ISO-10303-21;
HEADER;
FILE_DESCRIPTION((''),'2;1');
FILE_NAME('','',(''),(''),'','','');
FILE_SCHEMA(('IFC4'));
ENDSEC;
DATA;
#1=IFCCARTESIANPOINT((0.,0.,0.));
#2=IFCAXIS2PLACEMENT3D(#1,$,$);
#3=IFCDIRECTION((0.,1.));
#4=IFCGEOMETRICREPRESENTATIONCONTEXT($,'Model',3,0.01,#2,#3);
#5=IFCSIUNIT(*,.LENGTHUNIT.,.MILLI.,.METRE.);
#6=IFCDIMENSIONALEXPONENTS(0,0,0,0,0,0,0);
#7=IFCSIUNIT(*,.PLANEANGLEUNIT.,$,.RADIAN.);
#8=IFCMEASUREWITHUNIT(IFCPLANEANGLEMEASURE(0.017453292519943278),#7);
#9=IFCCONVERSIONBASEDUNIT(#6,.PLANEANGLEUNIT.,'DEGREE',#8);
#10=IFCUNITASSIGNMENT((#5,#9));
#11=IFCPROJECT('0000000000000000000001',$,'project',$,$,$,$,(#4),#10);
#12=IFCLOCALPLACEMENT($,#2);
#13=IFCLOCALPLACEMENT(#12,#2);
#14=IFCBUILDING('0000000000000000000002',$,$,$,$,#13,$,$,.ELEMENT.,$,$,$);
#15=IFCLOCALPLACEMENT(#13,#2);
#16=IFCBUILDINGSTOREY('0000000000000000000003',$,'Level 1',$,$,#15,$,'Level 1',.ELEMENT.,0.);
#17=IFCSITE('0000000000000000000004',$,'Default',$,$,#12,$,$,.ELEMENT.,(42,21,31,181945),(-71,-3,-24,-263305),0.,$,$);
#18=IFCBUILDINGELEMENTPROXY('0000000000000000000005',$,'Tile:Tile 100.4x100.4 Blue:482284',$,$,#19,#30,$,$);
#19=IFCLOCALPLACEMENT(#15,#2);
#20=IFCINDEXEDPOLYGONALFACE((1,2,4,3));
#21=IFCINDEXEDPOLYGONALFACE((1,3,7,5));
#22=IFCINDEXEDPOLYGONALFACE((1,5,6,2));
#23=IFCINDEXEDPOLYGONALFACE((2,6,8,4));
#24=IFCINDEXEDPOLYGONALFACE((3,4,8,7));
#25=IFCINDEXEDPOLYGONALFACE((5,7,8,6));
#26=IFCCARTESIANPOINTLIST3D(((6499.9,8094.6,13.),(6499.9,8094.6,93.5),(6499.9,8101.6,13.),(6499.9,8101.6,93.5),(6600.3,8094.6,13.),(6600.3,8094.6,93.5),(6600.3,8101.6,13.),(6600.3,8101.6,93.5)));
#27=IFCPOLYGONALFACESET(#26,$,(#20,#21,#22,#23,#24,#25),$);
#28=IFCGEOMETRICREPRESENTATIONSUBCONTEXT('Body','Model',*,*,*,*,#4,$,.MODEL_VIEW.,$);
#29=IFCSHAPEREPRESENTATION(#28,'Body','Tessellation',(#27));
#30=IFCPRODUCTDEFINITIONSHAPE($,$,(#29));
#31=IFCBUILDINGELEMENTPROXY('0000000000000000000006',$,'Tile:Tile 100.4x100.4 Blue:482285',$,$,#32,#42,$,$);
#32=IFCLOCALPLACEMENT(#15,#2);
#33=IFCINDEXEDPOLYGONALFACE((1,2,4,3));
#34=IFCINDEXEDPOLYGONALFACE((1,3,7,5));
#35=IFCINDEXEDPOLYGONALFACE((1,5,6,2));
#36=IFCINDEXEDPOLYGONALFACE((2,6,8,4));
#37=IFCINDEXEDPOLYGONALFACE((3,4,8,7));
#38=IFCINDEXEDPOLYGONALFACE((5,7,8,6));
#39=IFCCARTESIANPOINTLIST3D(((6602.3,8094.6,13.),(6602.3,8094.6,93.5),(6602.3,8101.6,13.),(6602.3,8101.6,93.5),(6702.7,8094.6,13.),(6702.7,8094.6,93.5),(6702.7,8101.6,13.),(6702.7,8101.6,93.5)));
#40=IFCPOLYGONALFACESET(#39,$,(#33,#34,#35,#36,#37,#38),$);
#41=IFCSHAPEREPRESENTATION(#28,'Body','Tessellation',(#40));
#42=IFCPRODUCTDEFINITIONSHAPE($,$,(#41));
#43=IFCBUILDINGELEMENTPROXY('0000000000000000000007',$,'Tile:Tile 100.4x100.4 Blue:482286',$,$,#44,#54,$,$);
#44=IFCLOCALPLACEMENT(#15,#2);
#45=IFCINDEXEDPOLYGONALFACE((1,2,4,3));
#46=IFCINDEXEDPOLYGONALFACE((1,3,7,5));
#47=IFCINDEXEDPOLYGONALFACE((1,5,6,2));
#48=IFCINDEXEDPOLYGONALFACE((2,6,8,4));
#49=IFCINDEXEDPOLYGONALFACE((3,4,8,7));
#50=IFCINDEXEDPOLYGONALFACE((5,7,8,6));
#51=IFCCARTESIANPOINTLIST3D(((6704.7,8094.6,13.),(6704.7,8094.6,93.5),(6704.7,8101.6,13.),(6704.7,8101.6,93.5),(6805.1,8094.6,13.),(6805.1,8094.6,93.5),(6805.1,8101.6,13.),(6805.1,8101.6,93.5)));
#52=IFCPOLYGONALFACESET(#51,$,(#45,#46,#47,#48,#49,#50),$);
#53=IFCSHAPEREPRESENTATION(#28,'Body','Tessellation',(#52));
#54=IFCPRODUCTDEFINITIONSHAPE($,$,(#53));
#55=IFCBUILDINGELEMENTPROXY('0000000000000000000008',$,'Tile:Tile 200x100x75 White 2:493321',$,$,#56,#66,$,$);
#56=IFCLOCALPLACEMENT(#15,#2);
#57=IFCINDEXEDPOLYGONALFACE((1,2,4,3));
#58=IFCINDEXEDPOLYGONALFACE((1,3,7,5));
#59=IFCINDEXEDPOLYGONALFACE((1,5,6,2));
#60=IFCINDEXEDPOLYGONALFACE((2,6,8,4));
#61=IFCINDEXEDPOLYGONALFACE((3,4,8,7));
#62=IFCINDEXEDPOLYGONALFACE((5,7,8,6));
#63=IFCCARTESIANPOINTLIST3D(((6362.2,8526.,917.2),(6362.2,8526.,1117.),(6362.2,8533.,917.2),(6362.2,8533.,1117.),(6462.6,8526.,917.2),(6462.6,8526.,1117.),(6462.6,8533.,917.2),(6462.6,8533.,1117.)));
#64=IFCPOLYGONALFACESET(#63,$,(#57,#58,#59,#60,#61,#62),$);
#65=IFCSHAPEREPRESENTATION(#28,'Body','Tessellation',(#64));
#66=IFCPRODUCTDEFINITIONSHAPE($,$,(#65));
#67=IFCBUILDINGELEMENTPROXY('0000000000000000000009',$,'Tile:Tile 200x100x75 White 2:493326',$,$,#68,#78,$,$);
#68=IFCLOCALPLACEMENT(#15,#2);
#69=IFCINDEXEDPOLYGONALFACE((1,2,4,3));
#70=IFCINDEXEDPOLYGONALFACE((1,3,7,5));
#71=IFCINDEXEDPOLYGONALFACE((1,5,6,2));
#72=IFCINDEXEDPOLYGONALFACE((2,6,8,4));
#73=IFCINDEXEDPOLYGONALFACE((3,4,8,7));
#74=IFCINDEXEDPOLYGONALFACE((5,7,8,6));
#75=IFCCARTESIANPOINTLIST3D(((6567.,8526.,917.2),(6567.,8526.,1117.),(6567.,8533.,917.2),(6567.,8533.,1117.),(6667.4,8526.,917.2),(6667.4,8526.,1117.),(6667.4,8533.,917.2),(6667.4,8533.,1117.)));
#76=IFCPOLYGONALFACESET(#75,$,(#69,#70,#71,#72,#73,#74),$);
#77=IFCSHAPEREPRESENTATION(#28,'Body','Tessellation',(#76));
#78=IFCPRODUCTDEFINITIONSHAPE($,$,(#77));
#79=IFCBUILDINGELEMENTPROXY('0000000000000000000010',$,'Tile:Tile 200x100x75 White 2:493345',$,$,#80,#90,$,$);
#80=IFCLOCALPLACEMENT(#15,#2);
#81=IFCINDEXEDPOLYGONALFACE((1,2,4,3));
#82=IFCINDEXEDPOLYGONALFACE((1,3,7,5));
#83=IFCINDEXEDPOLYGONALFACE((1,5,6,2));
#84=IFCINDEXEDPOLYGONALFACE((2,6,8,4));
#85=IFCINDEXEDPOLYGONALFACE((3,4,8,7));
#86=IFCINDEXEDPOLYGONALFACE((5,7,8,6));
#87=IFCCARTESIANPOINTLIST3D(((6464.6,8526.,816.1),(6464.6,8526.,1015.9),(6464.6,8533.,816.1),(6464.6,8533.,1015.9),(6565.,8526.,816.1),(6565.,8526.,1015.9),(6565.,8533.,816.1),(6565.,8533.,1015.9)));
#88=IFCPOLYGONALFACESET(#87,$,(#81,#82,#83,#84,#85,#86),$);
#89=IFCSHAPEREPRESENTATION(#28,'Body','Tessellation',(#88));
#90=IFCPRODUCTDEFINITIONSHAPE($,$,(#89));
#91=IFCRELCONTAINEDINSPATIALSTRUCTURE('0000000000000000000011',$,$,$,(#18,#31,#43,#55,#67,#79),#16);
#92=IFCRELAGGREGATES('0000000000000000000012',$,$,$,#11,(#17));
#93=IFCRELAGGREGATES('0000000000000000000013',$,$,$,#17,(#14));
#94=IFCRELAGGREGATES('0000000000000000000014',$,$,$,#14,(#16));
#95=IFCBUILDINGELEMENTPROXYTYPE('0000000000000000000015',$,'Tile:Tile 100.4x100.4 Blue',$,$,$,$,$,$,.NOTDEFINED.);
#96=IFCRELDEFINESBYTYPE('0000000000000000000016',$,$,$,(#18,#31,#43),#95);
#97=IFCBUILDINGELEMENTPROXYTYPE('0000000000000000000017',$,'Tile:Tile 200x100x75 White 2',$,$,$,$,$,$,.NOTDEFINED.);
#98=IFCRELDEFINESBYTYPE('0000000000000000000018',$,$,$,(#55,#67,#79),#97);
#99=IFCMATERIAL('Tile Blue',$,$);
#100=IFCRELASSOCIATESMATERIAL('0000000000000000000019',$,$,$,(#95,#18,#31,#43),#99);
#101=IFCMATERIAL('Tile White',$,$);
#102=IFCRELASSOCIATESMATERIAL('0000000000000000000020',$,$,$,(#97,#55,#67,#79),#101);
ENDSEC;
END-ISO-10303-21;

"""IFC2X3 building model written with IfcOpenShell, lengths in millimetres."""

from ifc_helpers import new_model, entity, si_unit, converted_unit, direction, frame, frame_2d, origin, origin_2d_with_axis, place, context, subcontext, project, spatial, rectangle, extrude, source, transform, mapped, material, type_object, type_shapes, element, save


model = new_model("IFC2X3")

# Units and contexts
model_context = context("Model", 3, precision=0.01, world=origin(), true_north=direction((0.0, 1.0)))
body_context = subcontext(model_context, "Body", "Model", "MODEL_VIEW")
ifc_project = project(units=[si_unit("LENGTHUNIT", "METRE", prefix="MILLI"), converted_unit("PLANEANGLEUNIT", "DEGREE", entity("IfcPlaneAngleMeasure", 0.017453292519943278), si_unit("PLANEANGLEUNIT", "RADIAN"), dimensions=[0, 0, 0, 0, 0, 0, 0])], contexts=[model_context])

# Site, building, storey
site_placement = place(None, origin())
site = spatial("IfcSite", under=ifc_project, at=site_placement, Name="Default", CompositionType="ELEMENT", RefLatitude=(42, 21, 31, 181945), RefLongitude=(-71, -3, -24, -263305), RefElevation=0.0)
building_placement = place(site_placement, origin())
building = spatial("IfcBuilding", under=site, at=building_placement, CompositionType="ELEMENT")
storey_placement = place(building_placement, origin())
storey = spatial("IfcBuildingStorey", under=building, at=storey_placement, Name="Level 1", LongName="Level 1", CompositionType="ELEMENT", Elevation=0.0)

# Building element proxies
ifc_material_1 = material(Name="Tile White")
ifc_material_2 = material(Name="Tile Blue")
building_element_proxy_type_1 = type_object("IfcBuildingElementProxyType", Name="Tile:Tile 100.4x100.4 Blue", PredefinedType="NOTDEFINED", material=ifc_material_2)
shared_shape_1 = source(origin(), body_context, "Body", "SweptSolid", [
    extrude(rectangle(XDim=80.5, YDim=100.4, at=origin_2d_with_axis()), frame((-50.2, -40.3, 0.0), z_axis=(0.0, 0.0, 1.0), x_axis=(0.0, -1.0, 0.0)), (0.0, 0.0, 1.0), 7.0),
])
type_shapes(building_element_proxy_type_1, [shared_shape_1])
for number, where, z_axis, x_axis, name in (
    (1, (6499.9, 8101.6, 13.0), (0.0, -1.0, 0.0), (-1.0, 0.0, 0.0), "Tile:Tile 100.4x100.4 Blue:482284"),
    (2, (6602.3, 8101.6, 13.0), (0.0, -1.0, 0.0), (-1.0, 0.0, 0.0), "Tile:Tile 100.4x100.4 Blue:482285"),
    (3, (6704.7, 8101.6, 13.0), (0.0, -1.0, 0.0), (-1.0, 0.0, 0.0), "Tile:Tile 100.4x100.4 Blue:482286"),
):
    element("IfcBuildingElementProxy", number, at=place(storey_placement, frame(where, z_axis=z_axis, x_axis=x_axis)), inside=storey, type_object=building_element_proxy_type_1, material=ifc_material_2, Name=name, context=body_context, shape_type="MappedRepresentation", body=[
        mapped(shared_shape_1, transform((0.0, 0.0, 0.0), scale=1.0)),
    ])
building_element_proxy_type_2 = type_object("IfcBuildingElementProxyType", Name="Tile:Tile 200x100x75 White 2", PredefinedType="NOTDEFINED", material=ifc_material_1)
shared_shape_2 = source(origin(), body_context, "Body", "SweptSolid", [
    extrude(rectangle(XDim=199.8, YDim=100.4, at=frame_2d((0.0, 0.0), x_axis=(1.0, 0.0))), frame((-50.2, -99.9, 0.0), z_axis=(0.0, 0.0, 1.0), x_axis=(0.0, -1.0, 0.0)), (0.0, 0.0, 1.0), 7.0),
])
type_shapes(building_element_proxy_type_2, [shared_shape_2])
for number, where, z_axis, x_axis, name in (
    (4, (6462.6, 8533.0, 1117.0), (0.0, -1.0, 0.0), (1.0, 0.0, 0.0), "Tile:Tile 200x100x75 White 2:493321"),
    (5, (6667.4, 8533.0, 1117.0), (0.0, -1.0, 0.0), (1.0, 0.0, 0.0), "Tile:Tile 200x100x75 White 2:493326"),
    (6, (6565.0, 8533.0, 1015.9), (0.0, -1.0, 0.0), (1.0, 0.0, 0.0), "Tile:Tile 200x100x75 White 2:493345"),
):
    element("IfcBuildingElementProxy", number, at=place(storey_placement, frame(where, z_axis=z_axis, x_axis=x_axis)), inside=storey, type_object=building_element_proxy_type_2, material=ifc_material_1, Name=name, context=body_context, shape_type="MappedRepresentation", body=[
        mapped(shared_shape_2, transform((0.0, 0.0, 0.0), scale=1.0)),
    ])

save(model, "model.ifc")
